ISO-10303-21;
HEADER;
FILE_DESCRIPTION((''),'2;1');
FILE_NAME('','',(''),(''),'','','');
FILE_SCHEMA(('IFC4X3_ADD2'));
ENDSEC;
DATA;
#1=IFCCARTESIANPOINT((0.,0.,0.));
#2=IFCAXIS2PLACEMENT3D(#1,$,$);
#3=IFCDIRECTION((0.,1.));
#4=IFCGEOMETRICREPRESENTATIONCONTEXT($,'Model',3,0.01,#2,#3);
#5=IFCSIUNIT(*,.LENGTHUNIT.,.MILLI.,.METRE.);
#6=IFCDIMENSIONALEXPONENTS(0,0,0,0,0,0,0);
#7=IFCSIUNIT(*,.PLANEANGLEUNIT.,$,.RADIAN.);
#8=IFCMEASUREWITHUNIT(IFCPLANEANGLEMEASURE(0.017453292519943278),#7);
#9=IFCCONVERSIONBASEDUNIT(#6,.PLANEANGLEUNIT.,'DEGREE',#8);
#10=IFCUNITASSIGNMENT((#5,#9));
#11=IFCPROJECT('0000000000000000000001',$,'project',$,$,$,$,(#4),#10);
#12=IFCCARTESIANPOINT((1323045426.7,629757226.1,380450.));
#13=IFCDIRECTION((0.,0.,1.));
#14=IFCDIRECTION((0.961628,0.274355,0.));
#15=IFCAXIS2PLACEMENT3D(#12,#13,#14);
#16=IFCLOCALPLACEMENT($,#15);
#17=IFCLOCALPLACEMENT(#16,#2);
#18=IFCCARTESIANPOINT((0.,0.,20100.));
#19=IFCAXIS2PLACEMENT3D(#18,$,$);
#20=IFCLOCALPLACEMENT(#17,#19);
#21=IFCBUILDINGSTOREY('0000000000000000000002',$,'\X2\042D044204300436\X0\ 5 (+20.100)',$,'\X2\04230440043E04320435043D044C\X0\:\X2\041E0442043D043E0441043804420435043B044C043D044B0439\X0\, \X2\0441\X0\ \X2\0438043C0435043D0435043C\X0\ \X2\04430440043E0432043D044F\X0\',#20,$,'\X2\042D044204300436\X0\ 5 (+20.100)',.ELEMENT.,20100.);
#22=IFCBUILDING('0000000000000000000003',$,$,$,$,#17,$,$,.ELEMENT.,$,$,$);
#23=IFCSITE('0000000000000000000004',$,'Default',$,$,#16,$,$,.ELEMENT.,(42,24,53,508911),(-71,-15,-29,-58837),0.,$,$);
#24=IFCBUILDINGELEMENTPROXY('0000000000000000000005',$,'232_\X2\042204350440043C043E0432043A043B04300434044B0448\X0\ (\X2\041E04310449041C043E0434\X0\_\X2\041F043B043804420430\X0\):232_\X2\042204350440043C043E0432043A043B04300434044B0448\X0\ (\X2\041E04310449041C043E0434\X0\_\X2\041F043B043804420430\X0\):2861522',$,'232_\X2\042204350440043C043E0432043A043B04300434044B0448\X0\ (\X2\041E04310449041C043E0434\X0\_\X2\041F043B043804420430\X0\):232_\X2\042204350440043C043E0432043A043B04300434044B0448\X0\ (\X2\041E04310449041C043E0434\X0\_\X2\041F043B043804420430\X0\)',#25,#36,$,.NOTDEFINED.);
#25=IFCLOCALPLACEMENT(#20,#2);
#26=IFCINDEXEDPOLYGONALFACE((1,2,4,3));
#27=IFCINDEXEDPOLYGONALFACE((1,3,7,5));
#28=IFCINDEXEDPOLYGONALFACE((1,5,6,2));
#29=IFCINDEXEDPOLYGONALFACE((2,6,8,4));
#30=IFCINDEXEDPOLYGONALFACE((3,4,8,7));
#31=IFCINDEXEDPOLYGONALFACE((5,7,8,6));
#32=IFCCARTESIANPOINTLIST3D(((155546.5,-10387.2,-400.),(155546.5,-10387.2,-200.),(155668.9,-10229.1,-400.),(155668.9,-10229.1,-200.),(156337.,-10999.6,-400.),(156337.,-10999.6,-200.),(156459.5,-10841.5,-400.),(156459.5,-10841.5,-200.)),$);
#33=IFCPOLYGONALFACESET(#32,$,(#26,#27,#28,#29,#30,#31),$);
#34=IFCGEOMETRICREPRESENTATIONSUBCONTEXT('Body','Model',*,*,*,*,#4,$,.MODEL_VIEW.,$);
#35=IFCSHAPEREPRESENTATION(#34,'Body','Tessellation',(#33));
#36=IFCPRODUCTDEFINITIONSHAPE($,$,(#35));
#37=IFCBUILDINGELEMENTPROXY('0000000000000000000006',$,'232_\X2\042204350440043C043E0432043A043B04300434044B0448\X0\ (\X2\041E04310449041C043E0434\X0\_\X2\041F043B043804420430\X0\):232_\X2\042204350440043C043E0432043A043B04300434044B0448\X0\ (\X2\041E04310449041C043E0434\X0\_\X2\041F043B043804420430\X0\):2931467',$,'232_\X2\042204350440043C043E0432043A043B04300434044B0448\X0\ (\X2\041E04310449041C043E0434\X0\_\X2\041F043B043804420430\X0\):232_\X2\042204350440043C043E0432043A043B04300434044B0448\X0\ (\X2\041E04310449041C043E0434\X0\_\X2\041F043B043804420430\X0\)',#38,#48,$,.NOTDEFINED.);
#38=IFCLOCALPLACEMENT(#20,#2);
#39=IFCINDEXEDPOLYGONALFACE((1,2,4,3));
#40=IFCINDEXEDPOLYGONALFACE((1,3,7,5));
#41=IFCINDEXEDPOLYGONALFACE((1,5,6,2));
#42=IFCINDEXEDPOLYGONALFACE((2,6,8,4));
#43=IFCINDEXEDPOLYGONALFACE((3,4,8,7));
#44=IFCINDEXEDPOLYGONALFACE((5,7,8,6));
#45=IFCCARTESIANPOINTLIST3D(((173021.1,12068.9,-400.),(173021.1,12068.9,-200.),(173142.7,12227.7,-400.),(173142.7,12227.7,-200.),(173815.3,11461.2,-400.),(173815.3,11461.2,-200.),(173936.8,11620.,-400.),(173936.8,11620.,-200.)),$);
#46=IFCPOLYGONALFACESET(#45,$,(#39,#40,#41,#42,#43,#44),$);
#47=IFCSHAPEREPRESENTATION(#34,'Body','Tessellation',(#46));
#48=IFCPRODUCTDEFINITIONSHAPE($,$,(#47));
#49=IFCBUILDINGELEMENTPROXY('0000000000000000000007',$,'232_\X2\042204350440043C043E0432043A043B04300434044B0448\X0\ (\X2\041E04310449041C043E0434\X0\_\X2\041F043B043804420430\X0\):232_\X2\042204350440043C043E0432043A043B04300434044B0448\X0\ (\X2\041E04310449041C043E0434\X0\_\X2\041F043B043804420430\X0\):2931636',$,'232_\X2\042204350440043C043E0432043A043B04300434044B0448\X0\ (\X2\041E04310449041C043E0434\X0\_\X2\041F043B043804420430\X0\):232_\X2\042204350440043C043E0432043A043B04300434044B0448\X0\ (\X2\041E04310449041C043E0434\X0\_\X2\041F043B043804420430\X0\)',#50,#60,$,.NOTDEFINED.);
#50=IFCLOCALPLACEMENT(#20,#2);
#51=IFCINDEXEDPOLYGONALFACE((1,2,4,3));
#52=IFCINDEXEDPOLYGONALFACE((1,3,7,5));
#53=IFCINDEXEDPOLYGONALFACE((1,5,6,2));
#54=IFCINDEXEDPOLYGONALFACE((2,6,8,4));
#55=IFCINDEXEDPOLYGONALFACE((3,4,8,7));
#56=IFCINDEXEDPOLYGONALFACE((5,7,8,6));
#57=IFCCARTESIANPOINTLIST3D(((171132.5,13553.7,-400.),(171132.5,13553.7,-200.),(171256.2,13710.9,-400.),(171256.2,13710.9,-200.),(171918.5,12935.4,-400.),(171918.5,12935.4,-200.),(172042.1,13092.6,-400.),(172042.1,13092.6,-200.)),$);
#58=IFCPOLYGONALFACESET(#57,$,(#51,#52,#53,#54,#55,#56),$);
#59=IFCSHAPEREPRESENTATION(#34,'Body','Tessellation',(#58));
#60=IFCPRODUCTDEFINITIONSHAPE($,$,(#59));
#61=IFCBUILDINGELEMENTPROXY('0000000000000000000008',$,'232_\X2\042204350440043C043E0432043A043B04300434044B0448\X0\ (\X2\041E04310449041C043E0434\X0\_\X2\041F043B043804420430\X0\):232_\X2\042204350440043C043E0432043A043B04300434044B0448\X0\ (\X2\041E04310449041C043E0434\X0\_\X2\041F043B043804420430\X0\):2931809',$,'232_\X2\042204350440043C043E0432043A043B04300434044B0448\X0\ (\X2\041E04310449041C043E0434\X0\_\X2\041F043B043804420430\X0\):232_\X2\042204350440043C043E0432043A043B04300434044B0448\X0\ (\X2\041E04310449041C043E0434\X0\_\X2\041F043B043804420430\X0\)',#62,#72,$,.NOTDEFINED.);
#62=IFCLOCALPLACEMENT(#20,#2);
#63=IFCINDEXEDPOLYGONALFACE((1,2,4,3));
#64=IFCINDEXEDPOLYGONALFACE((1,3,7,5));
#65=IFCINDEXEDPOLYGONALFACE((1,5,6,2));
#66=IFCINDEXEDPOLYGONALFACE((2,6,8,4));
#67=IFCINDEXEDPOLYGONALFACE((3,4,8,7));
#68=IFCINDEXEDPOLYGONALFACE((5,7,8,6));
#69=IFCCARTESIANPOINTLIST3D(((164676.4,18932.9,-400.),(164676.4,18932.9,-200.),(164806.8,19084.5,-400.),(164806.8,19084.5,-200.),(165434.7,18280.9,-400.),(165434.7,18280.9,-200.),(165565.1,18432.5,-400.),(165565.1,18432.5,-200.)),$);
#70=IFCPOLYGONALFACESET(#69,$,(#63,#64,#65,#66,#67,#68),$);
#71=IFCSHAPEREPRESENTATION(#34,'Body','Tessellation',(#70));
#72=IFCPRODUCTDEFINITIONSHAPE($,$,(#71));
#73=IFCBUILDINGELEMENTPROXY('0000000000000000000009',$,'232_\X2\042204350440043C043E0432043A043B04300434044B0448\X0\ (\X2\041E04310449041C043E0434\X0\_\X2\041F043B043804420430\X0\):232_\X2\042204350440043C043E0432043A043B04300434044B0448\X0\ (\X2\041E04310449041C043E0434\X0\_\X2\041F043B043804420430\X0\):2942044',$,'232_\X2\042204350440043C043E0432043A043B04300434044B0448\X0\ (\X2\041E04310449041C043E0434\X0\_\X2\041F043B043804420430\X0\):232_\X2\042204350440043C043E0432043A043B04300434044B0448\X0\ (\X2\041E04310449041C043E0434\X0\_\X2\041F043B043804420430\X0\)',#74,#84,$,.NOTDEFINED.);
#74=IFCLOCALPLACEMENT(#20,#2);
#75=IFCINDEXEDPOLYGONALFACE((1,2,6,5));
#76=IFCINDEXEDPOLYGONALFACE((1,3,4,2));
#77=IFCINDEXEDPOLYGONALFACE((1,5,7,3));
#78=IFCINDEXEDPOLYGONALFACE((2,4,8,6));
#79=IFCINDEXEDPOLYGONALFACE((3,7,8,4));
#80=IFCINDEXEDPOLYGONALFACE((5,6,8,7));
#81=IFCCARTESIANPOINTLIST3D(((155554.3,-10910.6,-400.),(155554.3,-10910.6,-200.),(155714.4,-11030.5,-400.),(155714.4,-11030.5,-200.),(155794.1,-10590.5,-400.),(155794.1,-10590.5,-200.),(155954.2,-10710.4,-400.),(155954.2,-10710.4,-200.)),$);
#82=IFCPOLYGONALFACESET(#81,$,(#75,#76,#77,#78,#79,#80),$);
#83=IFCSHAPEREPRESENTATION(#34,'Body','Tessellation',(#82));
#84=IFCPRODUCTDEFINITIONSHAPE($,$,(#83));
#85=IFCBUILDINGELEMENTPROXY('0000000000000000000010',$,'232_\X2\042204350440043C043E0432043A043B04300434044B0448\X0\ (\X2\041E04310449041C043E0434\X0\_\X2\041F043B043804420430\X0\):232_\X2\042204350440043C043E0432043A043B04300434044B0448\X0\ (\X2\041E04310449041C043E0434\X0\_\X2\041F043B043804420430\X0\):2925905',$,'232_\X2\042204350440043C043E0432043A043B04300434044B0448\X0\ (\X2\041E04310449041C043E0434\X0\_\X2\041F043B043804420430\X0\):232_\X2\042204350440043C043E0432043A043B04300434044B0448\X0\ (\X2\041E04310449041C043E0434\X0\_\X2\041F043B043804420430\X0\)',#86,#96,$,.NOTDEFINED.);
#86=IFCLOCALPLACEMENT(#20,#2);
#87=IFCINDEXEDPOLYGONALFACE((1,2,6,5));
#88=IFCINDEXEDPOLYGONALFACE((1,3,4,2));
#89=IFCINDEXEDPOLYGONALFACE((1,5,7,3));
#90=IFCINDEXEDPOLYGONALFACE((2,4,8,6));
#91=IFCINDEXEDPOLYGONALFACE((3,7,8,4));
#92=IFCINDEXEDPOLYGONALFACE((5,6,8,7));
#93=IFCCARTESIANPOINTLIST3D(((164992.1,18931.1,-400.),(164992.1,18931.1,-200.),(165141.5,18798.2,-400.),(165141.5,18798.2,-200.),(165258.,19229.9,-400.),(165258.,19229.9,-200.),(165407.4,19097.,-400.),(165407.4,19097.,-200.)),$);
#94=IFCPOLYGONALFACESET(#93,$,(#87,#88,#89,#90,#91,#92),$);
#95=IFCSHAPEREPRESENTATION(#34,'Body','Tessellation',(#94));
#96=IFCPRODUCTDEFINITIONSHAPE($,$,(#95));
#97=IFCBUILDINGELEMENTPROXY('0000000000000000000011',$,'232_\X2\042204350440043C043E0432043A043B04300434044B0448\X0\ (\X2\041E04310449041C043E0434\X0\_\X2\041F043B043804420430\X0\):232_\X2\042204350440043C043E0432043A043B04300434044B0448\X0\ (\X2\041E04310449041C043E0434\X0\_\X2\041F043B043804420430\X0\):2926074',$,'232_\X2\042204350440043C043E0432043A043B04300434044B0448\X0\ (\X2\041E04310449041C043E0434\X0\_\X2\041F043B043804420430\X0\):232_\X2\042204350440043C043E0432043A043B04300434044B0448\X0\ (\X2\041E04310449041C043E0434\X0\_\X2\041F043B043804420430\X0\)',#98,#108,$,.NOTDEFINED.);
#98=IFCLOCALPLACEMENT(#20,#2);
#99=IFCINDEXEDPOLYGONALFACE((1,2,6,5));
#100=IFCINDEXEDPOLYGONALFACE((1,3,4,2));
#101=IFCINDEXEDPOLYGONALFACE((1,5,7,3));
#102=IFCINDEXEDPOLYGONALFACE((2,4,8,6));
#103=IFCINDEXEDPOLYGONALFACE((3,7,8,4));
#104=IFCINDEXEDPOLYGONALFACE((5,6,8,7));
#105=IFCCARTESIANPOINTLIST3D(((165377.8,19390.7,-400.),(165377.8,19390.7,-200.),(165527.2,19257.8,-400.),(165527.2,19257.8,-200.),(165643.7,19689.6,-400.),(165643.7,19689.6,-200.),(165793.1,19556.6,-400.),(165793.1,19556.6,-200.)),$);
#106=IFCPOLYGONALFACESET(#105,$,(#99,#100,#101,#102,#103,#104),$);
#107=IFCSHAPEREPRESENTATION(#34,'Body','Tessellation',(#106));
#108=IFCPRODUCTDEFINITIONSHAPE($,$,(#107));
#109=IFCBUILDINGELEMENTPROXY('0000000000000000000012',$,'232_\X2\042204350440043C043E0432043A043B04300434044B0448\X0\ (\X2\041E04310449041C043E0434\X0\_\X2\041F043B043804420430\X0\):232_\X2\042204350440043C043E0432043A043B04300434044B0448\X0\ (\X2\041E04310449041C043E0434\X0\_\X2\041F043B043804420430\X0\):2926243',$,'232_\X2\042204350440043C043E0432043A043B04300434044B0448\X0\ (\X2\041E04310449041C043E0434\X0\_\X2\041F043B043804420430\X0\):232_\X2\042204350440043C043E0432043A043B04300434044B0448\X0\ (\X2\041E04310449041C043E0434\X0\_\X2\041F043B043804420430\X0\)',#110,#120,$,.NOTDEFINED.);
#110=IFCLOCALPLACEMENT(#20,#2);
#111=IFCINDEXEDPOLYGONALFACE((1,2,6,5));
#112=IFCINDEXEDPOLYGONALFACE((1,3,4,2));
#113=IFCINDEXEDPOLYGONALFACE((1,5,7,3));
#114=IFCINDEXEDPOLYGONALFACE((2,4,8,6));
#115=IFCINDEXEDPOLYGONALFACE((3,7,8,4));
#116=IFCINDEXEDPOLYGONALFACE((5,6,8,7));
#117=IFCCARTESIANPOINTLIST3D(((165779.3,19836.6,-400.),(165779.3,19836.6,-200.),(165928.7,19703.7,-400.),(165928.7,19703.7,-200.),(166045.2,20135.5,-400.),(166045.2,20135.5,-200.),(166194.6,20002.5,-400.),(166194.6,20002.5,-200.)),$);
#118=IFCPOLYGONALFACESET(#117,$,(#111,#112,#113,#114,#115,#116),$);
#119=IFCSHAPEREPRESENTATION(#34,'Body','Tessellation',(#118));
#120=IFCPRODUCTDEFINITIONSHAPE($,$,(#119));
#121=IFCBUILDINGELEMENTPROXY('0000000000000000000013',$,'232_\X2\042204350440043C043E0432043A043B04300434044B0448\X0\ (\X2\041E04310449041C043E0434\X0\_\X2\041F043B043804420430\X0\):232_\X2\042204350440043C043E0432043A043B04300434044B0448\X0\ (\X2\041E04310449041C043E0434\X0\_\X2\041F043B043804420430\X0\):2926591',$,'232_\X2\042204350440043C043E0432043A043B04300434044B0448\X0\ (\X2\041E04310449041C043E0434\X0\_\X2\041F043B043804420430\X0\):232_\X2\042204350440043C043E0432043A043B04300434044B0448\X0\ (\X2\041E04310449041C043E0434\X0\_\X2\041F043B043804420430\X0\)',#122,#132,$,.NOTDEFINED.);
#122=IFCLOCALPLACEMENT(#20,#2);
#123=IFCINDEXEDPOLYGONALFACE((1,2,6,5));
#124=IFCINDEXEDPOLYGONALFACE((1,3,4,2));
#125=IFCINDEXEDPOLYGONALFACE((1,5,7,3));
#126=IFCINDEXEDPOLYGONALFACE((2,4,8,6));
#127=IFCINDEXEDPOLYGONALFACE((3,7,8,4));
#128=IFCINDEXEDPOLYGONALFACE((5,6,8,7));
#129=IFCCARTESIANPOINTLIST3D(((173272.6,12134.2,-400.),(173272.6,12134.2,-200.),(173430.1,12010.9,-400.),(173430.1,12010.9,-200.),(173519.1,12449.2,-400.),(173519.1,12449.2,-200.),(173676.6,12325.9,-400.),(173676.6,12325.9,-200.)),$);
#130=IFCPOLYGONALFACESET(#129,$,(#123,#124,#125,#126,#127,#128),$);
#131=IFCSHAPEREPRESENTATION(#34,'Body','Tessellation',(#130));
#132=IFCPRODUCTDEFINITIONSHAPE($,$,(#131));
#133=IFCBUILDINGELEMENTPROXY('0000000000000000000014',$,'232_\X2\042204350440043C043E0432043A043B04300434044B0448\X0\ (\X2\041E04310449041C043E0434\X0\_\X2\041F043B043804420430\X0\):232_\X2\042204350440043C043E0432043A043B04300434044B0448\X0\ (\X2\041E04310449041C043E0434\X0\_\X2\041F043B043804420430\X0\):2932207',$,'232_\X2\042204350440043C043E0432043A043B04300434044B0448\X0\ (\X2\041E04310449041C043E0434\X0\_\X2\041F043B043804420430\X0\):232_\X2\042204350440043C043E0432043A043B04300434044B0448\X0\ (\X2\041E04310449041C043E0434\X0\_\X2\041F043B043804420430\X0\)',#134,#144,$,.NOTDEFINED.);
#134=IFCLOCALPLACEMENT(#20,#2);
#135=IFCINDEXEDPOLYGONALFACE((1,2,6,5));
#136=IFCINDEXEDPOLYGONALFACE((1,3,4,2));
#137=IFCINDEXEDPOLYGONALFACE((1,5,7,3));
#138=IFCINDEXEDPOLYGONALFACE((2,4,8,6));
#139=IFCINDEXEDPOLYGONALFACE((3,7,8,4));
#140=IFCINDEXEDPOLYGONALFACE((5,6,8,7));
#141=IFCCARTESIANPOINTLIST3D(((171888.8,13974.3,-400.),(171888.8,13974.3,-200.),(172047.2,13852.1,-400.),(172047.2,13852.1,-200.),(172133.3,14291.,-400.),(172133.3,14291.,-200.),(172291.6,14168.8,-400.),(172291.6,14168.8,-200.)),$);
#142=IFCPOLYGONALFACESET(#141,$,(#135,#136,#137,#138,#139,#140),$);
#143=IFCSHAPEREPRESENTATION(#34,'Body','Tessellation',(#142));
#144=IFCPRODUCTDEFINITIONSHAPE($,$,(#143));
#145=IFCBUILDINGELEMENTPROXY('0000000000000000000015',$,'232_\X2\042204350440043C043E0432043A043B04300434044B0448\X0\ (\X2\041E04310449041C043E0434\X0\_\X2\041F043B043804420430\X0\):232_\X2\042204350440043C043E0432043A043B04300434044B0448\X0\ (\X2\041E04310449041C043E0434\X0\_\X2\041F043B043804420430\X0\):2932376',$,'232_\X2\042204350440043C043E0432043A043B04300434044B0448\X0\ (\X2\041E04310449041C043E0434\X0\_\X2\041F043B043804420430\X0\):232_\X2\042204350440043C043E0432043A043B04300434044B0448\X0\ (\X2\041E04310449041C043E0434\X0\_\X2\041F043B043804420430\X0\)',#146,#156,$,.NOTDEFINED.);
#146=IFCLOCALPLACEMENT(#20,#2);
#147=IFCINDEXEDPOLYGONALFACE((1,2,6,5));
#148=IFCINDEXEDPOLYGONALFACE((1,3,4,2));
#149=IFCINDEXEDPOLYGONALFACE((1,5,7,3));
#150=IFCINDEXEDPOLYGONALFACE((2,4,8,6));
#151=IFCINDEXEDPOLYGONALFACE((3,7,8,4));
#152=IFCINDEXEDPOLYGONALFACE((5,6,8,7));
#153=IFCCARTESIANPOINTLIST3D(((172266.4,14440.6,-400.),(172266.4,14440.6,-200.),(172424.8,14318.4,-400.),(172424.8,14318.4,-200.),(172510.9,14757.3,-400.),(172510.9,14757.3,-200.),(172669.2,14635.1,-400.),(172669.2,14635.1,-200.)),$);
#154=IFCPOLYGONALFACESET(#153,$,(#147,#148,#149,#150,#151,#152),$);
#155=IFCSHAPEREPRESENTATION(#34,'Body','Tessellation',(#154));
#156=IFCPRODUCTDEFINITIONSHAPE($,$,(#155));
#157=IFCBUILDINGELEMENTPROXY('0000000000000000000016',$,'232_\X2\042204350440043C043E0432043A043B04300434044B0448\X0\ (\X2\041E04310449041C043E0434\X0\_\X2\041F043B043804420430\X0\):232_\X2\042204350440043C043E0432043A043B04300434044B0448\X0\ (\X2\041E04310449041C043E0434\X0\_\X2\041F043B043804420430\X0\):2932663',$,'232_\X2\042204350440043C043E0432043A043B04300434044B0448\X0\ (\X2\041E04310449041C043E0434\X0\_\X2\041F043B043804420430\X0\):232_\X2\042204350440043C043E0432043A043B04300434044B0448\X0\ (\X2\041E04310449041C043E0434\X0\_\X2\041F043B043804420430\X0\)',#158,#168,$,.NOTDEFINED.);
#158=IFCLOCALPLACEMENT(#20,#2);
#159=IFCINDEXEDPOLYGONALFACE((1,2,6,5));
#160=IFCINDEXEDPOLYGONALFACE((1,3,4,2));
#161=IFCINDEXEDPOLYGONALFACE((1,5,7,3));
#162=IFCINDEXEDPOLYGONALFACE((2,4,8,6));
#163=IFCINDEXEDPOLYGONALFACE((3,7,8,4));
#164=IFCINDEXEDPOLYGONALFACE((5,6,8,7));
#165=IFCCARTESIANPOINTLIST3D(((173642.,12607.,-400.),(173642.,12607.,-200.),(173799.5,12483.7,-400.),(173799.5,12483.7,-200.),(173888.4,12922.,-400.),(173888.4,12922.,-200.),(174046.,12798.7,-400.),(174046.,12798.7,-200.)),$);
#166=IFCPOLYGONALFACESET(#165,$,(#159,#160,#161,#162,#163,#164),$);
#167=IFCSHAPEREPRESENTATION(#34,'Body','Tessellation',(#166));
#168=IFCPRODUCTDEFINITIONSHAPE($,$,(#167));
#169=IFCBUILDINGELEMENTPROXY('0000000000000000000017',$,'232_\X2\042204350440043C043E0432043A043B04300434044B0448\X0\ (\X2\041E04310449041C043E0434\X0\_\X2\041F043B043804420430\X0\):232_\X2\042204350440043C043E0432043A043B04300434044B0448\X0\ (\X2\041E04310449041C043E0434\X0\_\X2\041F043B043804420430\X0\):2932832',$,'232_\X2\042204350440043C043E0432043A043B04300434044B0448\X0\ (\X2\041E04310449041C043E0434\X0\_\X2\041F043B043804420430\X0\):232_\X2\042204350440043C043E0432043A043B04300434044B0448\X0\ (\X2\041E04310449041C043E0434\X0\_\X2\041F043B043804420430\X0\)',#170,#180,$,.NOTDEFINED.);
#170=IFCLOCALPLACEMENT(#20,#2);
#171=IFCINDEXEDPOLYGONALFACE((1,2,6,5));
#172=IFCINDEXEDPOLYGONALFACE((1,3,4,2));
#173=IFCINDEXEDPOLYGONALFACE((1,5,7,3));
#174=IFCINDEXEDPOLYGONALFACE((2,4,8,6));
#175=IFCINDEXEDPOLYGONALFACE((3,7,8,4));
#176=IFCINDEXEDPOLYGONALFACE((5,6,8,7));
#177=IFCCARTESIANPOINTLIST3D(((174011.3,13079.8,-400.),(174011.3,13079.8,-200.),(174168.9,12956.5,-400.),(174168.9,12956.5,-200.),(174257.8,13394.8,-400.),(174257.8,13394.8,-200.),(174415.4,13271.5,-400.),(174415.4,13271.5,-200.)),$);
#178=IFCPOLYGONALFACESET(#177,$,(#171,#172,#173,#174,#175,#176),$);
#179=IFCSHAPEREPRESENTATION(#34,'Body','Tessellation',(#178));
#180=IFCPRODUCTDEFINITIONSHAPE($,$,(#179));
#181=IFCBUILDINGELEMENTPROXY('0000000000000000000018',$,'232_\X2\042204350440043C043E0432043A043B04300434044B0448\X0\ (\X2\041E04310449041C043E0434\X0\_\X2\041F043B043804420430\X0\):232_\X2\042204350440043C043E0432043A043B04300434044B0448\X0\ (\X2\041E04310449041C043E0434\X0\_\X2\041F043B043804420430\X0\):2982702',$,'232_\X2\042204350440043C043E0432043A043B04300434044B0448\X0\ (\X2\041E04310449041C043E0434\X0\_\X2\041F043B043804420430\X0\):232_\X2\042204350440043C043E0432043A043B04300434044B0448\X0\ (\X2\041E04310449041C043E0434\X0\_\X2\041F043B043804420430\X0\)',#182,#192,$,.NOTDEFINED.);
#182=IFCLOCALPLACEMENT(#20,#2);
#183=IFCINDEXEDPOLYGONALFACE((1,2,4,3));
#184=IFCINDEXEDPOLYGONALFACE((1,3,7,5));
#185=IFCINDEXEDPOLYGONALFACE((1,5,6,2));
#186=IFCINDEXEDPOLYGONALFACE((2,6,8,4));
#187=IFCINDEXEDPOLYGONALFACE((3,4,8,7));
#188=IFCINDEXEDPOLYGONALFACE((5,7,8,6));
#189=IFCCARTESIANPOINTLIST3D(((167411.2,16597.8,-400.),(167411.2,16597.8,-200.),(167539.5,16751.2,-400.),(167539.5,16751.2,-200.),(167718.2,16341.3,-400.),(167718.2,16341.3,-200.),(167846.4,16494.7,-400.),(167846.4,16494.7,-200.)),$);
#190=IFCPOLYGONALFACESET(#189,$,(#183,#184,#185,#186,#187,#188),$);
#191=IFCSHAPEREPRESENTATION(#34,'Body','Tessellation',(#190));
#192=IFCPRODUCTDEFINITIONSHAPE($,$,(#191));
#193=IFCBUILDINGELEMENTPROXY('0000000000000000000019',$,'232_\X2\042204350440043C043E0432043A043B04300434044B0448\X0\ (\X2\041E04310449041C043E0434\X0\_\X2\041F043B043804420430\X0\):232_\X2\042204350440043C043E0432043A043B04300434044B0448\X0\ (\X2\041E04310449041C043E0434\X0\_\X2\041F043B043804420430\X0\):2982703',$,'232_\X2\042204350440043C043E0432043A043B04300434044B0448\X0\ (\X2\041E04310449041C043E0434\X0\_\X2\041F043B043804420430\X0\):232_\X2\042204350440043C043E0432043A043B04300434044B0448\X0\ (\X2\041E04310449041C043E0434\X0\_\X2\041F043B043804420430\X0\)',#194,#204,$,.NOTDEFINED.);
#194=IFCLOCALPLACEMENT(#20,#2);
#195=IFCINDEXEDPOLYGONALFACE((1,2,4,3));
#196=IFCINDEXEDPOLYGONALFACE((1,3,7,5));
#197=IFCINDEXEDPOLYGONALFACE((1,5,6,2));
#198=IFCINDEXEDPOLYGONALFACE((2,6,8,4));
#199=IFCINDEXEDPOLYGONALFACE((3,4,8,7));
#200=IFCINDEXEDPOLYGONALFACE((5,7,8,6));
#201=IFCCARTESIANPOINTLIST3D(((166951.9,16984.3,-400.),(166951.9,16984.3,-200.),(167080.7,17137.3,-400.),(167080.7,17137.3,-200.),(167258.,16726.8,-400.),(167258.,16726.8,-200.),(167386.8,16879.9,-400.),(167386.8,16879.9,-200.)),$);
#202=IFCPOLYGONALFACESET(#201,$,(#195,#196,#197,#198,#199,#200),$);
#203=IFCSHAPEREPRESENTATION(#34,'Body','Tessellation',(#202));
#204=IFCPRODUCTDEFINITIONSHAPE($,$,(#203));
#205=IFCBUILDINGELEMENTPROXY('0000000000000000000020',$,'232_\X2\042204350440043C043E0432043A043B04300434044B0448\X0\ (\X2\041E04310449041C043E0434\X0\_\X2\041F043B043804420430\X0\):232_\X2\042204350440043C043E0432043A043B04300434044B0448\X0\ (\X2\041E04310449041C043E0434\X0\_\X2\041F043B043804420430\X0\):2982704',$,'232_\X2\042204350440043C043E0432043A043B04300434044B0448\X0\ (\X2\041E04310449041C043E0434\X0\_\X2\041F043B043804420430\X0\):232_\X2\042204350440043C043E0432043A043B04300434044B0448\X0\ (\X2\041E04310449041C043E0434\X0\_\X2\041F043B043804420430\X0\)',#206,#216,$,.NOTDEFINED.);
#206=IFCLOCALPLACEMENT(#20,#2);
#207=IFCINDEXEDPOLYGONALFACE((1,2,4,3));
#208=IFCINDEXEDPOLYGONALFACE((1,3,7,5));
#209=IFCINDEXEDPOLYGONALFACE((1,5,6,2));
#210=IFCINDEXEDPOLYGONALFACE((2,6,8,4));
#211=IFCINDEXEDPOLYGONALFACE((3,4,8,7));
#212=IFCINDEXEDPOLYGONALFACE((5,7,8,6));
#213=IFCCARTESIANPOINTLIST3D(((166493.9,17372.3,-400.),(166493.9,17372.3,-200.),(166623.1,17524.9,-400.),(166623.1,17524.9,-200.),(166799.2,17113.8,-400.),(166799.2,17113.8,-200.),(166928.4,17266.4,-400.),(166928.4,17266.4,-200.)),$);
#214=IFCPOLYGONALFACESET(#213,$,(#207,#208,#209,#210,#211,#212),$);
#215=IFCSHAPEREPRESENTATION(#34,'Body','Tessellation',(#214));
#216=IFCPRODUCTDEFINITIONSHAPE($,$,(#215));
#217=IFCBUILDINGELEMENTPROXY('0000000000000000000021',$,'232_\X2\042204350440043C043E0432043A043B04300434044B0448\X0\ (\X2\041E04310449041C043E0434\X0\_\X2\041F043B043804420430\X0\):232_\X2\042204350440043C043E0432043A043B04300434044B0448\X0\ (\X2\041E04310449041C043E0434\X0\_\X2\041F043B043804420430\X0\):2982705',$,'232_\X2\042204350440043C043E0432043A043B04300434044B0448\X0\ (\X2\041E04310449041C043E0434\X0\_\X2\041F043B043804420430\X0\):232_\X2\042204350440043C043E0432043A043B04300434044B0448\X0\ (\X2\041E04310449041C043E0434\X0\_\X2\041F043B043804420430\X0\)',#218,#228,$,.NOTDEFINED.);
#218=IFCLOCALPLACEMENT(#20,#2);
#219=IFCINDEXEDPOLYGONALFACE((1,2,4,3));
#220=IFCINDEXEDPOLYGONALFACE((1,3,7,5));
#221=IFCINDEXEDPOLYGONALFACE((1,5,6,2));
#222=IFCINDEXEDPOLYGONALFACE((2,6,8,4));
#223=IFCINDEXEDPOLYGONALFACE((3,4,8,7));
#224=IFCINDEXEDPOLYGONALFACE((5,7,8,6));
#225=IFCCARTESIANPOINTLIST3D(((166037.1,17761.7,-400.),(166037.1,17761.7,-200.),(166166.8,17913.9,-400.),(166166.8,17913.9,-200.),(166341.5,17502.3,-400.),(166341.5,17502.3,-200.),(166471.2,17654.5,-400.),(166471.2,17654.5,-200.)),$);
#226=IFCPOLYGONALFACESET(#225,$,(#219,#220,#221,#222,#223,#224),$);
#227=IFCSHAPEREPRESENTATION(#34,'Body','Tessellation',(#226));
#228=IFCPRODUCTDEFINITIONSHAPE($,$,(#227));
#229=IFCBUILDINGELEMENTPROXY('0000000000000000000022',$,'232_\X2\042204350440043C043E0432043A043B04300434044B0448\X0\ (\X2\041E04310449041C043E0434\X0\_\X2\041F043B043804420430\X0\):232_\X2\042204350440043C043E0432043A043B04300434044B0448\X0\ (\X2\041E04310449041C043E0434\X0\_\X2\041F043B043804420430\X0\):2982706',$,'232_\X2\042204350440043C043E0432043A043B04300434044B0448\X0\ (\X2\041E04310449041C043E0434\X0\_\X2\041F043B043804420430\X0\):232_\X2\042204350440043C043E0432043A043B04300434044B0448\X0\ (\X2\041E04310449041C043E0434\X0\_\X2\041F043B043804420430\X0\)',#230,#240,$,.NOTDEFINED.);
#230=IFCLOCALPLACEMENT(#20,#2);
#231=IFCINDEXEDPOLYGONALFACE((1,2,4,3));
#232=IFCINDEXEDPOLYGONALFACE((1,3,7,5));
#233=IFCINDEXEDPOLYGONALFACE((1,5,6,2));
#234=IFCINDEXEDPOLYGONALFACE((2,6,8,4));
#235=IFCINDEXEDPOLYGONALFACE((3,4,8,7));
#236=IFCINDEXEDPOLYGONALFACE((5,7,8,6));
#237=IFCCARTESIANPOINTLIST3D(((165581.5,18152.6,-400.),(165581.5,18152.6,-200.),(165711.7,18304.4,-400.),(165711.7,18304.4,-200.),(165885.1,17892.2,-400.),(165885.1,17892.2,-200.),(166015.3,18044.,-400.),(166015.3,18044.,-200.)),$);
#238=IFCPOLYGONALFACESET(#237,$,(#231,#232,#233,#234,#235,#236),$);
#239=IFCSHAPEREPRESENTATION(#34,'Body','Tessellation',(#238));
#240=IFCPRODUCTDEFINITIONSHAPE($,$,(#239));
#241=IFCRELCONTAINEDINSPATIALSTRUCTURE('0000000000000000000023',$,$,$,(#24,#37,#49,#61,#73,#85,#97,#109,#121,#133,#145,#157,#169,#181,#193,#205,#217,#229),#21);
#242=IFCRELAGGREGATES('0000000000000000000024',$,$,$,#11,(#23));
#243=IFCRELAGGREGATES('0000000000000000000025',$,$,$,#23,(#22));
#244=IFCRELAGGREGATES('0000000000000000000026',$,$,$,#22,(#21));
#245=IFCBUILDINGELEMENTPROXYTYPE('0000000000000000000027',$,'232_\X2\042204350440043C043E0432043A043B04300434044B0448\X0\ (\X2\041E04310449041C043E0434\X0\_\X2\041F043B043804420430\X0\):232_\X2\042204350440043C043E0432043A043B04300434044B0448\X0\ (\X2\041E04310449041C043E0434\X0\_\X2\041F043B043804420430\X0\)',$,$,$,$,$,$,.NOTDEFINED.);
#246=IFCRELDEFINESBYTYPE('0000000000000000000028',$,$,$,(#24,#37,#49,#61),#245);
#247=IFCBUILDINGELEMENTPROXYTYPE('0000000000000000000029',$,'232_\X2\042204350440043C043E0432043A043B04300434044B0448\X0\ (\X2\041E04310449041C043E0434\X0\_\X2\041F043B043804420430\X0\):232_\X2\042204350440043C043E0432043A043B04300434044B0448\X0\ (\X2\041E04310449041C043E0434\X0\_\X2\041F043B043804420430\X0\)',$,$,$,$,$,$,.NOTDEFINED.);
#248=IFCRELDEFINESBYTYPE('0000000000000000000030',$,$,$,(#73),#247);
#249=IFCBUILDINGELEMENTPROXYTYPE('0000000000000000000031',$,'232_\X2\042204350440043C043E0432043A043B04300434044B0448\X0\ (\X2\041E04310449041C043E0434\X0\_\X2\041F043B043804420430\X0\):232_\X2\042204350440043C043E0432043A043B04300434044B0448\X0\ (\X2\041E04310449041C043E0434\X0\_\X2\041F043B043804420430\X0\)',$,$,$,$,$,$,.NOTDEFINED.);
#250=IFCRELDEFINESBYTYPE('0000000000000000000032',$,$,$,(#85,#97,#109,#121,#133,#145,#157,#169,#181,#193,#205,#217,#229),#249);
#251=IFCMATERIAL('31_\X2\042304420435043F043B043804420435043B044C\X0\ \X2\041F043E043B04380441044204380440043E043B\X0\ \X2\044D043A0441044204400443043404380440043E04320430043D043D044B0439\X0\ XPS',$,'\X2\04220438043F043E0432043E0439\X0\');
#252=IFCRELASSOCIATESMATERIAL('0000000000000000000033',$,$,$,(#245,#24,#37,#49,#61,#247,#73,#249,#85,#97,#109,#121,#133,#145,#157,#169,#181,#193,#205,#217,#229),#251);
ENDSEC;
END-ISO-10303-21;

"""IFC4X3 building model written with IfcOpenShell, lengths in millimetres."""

from ifc_helpers import new_model, entity, si_unit, converted_unit, direction, frame, origin, origin_2d_with_axis, place, context, subcontext, project, spatial, rectangle, extrude, source, transform, mapped, material, type_object, type_shapes, element, save


model = new_model("IFC4X3")

# Units and contexts
model_context = context("Model", 3, precision=0.01, world=origin(), true_north=direction((0.0, 1.0)))
body_context = subcontext(model_context, "Body", "Model", "MODEL_VIEW")
ifc_project = project(units=[si_unit("LENGTHUNIT", "METRE", prefix="MILLI"), converted_unit("PLANEANGLEUNIT", "DEGREE", entity("IfcPlaneAngleMeasure", 0.017453292519943278), si_unit("PLANEANGLEUNIT", "RADIAN"), dimensions=[0, 0, 0, 0, 0, 0, 0])], contexts=[model_context])

# Site, building, storey
site_placement = place(None, frame((1323045426.7, 629757226.1, 380450.0), z_axis=(0.0, 0.0, 1.0), x_axis=(0.961628, 0.274355, 0.0)))
site = spatial("IfcSite", under=ifc_project, at=site_placement, Name="Default", CompositionType="ELEMENT", RefLatitude=(42, 24, 53, 508911), RefLongitude=(-71, -15, -29, -58837), RefElevation=0.0)
building_placement = place(site_placement, origin())
building = spatial("IfcBuilding", under=site, at=building_placement, CompositionType="ELEMENT")
storey_placement = place(building_placement, frame((0.0, 0.0, 20100.0)))
storey = spatial("IfcBuildingStorey", under=building, at=storey_placement, Name="Этаж 5 (+20.100)", ObjectType="Уровень:Относительный, с именем уровня", LongName="Этаж 5 (+20.100)", CompositionType="ELEMENT", Elevation=20100.0)

# Building element proxies
ifc_material = material(Name="31_Утеплитель Полистирол экструдированный XPS", Category="Типовой")
building_element_proxy_type_1 = type_object("IfcBuildingElementProxyType", Name="232_Термовкладыш (ОбщМод_Плита):232_Термовкладыш (ОбщМод_Плита)", PredefinedType="NOTDEFINED", material=ifc_material)
shared_shape_1 = source(origin(), body_context, "Body", "SweptSolid", [
    extrude(rectangle(XDim=1000.0, YDim=200.0, at=origin_2d_with_axis()), frame((500.0, 0.0, -200.0), z_axis=(0.0, 0.0, 1.0), x_axis=(-1.0, 0.0, 0.0)), (0.0, 0.0, 1.0), 200.0),
])
type_shapes(building_element_proxy_type_1, [shared_shape_1])
for number, where, z_axis, x_axis, name in (
    (1, (155607.7, -10308.2, -200.0), (0.0, 0.0, 1.0), (0.790557, -0.612389, 0.0), "232_Термовкладыш (ОбщМод_Плита):232_Термовкладыш (ОбщМод_Плита):2861522"),
    (2, (173876.0, 11540.6, -200.0), (0.0, 0.0, 1.0), (-0.794148, 0.607724, 0.0), "232_Термовкладыш (ОбщМод_Плита):232_Термовкладыш (ОбщМод_Плита):2931467"),
    (3, (171980.3, 13014.0, -200.0), (0.0, 0.0, 1.0), (-0.785945, 0.618296, 0.0), "232_Термовкладыш (ОбщМод_Плита):232_Термовкладыш (ОбщМод_Плита):2931636"),
    (4, (165499.9, 18356.7, -200.0), (0.0, 0.0, 1.0), (-0.758212, 0.652008, 0.0), "232_Термовкладыш (ОбщМод_Плита):232_Термовкладыш (ОбщМод_Плита):2931809"),
):
    element("IfcBuildingElementProxy", number, at=place(storey_placement, frame(where, z_axis=z_axis, x_axis=x_axis)), inside=storey, type_object=building_element_proxy_type_1, material=ifc_material, Name=name, ObjectType="232_Термовкладыш (ОбщМод_Плита):232_Термовкладыш (ОбщМод_Плита)", PredefinedType="NOTDEFINED", context=body_context, shape_type="MappedRepresentation", body=[
        mapped(shared_shape_1, transform((0.0, 0.0, 0.0), scale=1.0)),
    ])
building_element_proxy_type_2 = type_object("IfcBuildingElementProxyType", Name="232_Термовкладыш (ОбщМод_Плита):232_Термовкладыш (ОбщМод_Плита)", PredefinedType="NOTDEFINED", material=ifc_material)
shared_shape_2 = source(origin(), body_context, "Body", "SweptSolid", [
    extrude(rectangle(XDim=200.0, YDim=400.0, at=origin_2d_with_axis()), frame((100.0, 0.0, -200.0), z_axis=(0.0, 0.0, 1.0), x_axis=(-1.0, 0.0, 0.0)), (0.0, 0.0, 1.0), 200.0),
])
type_shapes(building_element_proxy_type_2, [shared_shape_2])
proxy_placement = place(storey_placement, frame((155674.2, -10750.6, -200.0), z_axis=(0.0, 0.0, 1.0), x_axis=(0.800379, -0.599495, 0.0)))
element("IfcBuildingElementProxy", 5, at=proxy_placement, inside=storey, type_object=building_element_proxy_type_2, material=ifc_material, Name="232_Термовкладыш (ОбщМод_Плита):232_Термовкладыш (ОбщМод_Плита):2942044", ObjectType="232_Термовкладыш (ОбщМод_Плита):232_Термовкладыш (ОбщМод_Плита)", PredefinedType="NOTDEFINED", context=body_context, shape_type="MappedRepresentation", body=[
    mapped(shared_shape_2, transform((0.0, 0.0, 0.0), scale=1.0)),
])
building_element_proxy_type_3 = type_object("IfcBuildingElementProxyType", Name="232_Термовкладыш (ОбщМод_Плита):232_Термовкладыш (ОбщМод_Плита)", PredefinedType="NOTDEFINED", material=ifc_material)
shared_shape_3 = source(origin(), body_context, "Body", "SweptSolid", [
    extrude(rectangle(XDim=400.0, YDim=200.0, at=origin_2d_with_axis()), frame((200.0, 0.0, -200.0), z_axis=(0.0, 0.0, 1.0), x_axis=(-1.0, 0.0, 0.0)), (0.0, 0.0, 1.0), 200.0),
])
type_shapes(building_element_proxy_type_3, [shared_shape_3])
for number, where, z_axis, x_axis, name in (
    (6, (165066.8, 18864.6, -200.0), (0.0, 0.0, 1.0), (0.664762, 0.747056, 0.0), "232_Термовкладыш (ОбщМод_Плита):232_Термовкладыш (ОбщМод_Плита):2925905"),
    (7, (165452.5, 19324.3, -200.0), (0.0, 0.0, 1.0), (0.664762, 0.747056, 0.0), "232_Термовкладыш (ОбщМод_Плита):232_Термовкладыш (ОбщМод_Плита):2926074"),
    (8, (165854.0, 19770.2, -200.0), (0.0, 0.0, 1.0), (0.664762, 0.747056, 0.0), "232_Термовкладыш (ОбщМод_Плита):232_Термовкладыш (ОбщМод_Плита):2926243"),
    (9, (173351.3, 12072.5, -200.0), (0.0, 0.0, 1.0), (0.616246, 0.787553, 0.0), "232_Термовкладыш (ОбщМод_Плита):232_Термовкладыш (ОбщМод_Плита):2926591"),
    (10, (171968.0, 13913.2, -200.0), (0.0, 0.0, 1.0), (0.61103, 0.791607, 0.0), "232_Термовкладыш (ОбщМод_Плита):232_Термовкладыш (ОбщМод_Плита):2932207"),
    (11, (172345.6, 14379.5, -200.0), (0.0, 0.0, 1.0), (0.61103, 0.791607, 0.0), "232_Термовкладыш (ОбщМод_Плита):232_Термовкладыш (ОбщМод_Плита):2932376"),
    (12, (173720.7, 12545.3, -200.0), (0.0, 0.0, 1.0), (0.616246, 0.787553, 0.0), "232_Термовкладыш (ОбщМод_Плита):232_Термовкладыш (ОбщМод_Плита):2932663"),
    (13, (174090.1, 13018.1, -200.0), (0.0, 0.0, 1.0), (0.616246, 0.787553, 0.0), "232_Термовкладыш (ОбщМод_Плита):232_Термовкладыш (ОбщМод_Плита):2932832"),
    (14, (167782.3, 16418.0, -200.0), (0.0, 0.0, 1.0), (-0.767295, 0.641294, 0.0), "232_Термовкладыш (ОбщМод_Плита):232_Термовкладыш (ОбщМод_Плита):2982702"),
    (15, (167322.4, 16803.3, -200.0), (0.0, 0.0, 1.0), (-0.765247, 0.643737, 0.0), "232_Термовкладыш (ОбщМод_Плита):232_Термовкладыш (ОбщМод_Плита):2982703"),
    (16, (166863.8, 17190.1, -200.0), (0.0, 0.0, 1.0), (-0.763191, 0.646172, 0.0), "232_Термовкладыш (ОбщМод_Плита):232_Термовкладыш (ОбщМод_Плита):2982704"),
    (17, (166406.4, 17578.4, -200.0), (0.0, 0.0, 1.0), (-0.761128, 0.648602, 0.0), "232_Термовкладыш (ОбщМод_Плита):232_Термовкладыш (ОбщМод_Плита):2982705"),
    (18, (165950.2, 17968.1, -200.0), (0.0, 0.0, 1.0), (-0.759057, 0.651024, 0.0), "232_Термовкладыш (ОбщМод_Плита):232_Термовкладыш (ОбщМод_Плита):2982706"),
):
    element("IfcBuildingElementProxy", number, at=place(storey_placement, frame(where, z_axis=z_axis, x_axis=x_axis)), inside=storey, type_object=building_element_proxy_type_3, material=ifc_material, Name=name, ObjectType="232_Термовкладыш (ОбщМод_Плита):232_Термовкладыш (ОбщМод_Плита)", PredefinedType="NOTDEFINED", context=body_context, shape_type="MappedRepresentation", body=[
        mapped(shared_shape_3, transform((0.0, 0.0, 0.0), scale=1.0)),
    ])

save(model, "model.ifc")
